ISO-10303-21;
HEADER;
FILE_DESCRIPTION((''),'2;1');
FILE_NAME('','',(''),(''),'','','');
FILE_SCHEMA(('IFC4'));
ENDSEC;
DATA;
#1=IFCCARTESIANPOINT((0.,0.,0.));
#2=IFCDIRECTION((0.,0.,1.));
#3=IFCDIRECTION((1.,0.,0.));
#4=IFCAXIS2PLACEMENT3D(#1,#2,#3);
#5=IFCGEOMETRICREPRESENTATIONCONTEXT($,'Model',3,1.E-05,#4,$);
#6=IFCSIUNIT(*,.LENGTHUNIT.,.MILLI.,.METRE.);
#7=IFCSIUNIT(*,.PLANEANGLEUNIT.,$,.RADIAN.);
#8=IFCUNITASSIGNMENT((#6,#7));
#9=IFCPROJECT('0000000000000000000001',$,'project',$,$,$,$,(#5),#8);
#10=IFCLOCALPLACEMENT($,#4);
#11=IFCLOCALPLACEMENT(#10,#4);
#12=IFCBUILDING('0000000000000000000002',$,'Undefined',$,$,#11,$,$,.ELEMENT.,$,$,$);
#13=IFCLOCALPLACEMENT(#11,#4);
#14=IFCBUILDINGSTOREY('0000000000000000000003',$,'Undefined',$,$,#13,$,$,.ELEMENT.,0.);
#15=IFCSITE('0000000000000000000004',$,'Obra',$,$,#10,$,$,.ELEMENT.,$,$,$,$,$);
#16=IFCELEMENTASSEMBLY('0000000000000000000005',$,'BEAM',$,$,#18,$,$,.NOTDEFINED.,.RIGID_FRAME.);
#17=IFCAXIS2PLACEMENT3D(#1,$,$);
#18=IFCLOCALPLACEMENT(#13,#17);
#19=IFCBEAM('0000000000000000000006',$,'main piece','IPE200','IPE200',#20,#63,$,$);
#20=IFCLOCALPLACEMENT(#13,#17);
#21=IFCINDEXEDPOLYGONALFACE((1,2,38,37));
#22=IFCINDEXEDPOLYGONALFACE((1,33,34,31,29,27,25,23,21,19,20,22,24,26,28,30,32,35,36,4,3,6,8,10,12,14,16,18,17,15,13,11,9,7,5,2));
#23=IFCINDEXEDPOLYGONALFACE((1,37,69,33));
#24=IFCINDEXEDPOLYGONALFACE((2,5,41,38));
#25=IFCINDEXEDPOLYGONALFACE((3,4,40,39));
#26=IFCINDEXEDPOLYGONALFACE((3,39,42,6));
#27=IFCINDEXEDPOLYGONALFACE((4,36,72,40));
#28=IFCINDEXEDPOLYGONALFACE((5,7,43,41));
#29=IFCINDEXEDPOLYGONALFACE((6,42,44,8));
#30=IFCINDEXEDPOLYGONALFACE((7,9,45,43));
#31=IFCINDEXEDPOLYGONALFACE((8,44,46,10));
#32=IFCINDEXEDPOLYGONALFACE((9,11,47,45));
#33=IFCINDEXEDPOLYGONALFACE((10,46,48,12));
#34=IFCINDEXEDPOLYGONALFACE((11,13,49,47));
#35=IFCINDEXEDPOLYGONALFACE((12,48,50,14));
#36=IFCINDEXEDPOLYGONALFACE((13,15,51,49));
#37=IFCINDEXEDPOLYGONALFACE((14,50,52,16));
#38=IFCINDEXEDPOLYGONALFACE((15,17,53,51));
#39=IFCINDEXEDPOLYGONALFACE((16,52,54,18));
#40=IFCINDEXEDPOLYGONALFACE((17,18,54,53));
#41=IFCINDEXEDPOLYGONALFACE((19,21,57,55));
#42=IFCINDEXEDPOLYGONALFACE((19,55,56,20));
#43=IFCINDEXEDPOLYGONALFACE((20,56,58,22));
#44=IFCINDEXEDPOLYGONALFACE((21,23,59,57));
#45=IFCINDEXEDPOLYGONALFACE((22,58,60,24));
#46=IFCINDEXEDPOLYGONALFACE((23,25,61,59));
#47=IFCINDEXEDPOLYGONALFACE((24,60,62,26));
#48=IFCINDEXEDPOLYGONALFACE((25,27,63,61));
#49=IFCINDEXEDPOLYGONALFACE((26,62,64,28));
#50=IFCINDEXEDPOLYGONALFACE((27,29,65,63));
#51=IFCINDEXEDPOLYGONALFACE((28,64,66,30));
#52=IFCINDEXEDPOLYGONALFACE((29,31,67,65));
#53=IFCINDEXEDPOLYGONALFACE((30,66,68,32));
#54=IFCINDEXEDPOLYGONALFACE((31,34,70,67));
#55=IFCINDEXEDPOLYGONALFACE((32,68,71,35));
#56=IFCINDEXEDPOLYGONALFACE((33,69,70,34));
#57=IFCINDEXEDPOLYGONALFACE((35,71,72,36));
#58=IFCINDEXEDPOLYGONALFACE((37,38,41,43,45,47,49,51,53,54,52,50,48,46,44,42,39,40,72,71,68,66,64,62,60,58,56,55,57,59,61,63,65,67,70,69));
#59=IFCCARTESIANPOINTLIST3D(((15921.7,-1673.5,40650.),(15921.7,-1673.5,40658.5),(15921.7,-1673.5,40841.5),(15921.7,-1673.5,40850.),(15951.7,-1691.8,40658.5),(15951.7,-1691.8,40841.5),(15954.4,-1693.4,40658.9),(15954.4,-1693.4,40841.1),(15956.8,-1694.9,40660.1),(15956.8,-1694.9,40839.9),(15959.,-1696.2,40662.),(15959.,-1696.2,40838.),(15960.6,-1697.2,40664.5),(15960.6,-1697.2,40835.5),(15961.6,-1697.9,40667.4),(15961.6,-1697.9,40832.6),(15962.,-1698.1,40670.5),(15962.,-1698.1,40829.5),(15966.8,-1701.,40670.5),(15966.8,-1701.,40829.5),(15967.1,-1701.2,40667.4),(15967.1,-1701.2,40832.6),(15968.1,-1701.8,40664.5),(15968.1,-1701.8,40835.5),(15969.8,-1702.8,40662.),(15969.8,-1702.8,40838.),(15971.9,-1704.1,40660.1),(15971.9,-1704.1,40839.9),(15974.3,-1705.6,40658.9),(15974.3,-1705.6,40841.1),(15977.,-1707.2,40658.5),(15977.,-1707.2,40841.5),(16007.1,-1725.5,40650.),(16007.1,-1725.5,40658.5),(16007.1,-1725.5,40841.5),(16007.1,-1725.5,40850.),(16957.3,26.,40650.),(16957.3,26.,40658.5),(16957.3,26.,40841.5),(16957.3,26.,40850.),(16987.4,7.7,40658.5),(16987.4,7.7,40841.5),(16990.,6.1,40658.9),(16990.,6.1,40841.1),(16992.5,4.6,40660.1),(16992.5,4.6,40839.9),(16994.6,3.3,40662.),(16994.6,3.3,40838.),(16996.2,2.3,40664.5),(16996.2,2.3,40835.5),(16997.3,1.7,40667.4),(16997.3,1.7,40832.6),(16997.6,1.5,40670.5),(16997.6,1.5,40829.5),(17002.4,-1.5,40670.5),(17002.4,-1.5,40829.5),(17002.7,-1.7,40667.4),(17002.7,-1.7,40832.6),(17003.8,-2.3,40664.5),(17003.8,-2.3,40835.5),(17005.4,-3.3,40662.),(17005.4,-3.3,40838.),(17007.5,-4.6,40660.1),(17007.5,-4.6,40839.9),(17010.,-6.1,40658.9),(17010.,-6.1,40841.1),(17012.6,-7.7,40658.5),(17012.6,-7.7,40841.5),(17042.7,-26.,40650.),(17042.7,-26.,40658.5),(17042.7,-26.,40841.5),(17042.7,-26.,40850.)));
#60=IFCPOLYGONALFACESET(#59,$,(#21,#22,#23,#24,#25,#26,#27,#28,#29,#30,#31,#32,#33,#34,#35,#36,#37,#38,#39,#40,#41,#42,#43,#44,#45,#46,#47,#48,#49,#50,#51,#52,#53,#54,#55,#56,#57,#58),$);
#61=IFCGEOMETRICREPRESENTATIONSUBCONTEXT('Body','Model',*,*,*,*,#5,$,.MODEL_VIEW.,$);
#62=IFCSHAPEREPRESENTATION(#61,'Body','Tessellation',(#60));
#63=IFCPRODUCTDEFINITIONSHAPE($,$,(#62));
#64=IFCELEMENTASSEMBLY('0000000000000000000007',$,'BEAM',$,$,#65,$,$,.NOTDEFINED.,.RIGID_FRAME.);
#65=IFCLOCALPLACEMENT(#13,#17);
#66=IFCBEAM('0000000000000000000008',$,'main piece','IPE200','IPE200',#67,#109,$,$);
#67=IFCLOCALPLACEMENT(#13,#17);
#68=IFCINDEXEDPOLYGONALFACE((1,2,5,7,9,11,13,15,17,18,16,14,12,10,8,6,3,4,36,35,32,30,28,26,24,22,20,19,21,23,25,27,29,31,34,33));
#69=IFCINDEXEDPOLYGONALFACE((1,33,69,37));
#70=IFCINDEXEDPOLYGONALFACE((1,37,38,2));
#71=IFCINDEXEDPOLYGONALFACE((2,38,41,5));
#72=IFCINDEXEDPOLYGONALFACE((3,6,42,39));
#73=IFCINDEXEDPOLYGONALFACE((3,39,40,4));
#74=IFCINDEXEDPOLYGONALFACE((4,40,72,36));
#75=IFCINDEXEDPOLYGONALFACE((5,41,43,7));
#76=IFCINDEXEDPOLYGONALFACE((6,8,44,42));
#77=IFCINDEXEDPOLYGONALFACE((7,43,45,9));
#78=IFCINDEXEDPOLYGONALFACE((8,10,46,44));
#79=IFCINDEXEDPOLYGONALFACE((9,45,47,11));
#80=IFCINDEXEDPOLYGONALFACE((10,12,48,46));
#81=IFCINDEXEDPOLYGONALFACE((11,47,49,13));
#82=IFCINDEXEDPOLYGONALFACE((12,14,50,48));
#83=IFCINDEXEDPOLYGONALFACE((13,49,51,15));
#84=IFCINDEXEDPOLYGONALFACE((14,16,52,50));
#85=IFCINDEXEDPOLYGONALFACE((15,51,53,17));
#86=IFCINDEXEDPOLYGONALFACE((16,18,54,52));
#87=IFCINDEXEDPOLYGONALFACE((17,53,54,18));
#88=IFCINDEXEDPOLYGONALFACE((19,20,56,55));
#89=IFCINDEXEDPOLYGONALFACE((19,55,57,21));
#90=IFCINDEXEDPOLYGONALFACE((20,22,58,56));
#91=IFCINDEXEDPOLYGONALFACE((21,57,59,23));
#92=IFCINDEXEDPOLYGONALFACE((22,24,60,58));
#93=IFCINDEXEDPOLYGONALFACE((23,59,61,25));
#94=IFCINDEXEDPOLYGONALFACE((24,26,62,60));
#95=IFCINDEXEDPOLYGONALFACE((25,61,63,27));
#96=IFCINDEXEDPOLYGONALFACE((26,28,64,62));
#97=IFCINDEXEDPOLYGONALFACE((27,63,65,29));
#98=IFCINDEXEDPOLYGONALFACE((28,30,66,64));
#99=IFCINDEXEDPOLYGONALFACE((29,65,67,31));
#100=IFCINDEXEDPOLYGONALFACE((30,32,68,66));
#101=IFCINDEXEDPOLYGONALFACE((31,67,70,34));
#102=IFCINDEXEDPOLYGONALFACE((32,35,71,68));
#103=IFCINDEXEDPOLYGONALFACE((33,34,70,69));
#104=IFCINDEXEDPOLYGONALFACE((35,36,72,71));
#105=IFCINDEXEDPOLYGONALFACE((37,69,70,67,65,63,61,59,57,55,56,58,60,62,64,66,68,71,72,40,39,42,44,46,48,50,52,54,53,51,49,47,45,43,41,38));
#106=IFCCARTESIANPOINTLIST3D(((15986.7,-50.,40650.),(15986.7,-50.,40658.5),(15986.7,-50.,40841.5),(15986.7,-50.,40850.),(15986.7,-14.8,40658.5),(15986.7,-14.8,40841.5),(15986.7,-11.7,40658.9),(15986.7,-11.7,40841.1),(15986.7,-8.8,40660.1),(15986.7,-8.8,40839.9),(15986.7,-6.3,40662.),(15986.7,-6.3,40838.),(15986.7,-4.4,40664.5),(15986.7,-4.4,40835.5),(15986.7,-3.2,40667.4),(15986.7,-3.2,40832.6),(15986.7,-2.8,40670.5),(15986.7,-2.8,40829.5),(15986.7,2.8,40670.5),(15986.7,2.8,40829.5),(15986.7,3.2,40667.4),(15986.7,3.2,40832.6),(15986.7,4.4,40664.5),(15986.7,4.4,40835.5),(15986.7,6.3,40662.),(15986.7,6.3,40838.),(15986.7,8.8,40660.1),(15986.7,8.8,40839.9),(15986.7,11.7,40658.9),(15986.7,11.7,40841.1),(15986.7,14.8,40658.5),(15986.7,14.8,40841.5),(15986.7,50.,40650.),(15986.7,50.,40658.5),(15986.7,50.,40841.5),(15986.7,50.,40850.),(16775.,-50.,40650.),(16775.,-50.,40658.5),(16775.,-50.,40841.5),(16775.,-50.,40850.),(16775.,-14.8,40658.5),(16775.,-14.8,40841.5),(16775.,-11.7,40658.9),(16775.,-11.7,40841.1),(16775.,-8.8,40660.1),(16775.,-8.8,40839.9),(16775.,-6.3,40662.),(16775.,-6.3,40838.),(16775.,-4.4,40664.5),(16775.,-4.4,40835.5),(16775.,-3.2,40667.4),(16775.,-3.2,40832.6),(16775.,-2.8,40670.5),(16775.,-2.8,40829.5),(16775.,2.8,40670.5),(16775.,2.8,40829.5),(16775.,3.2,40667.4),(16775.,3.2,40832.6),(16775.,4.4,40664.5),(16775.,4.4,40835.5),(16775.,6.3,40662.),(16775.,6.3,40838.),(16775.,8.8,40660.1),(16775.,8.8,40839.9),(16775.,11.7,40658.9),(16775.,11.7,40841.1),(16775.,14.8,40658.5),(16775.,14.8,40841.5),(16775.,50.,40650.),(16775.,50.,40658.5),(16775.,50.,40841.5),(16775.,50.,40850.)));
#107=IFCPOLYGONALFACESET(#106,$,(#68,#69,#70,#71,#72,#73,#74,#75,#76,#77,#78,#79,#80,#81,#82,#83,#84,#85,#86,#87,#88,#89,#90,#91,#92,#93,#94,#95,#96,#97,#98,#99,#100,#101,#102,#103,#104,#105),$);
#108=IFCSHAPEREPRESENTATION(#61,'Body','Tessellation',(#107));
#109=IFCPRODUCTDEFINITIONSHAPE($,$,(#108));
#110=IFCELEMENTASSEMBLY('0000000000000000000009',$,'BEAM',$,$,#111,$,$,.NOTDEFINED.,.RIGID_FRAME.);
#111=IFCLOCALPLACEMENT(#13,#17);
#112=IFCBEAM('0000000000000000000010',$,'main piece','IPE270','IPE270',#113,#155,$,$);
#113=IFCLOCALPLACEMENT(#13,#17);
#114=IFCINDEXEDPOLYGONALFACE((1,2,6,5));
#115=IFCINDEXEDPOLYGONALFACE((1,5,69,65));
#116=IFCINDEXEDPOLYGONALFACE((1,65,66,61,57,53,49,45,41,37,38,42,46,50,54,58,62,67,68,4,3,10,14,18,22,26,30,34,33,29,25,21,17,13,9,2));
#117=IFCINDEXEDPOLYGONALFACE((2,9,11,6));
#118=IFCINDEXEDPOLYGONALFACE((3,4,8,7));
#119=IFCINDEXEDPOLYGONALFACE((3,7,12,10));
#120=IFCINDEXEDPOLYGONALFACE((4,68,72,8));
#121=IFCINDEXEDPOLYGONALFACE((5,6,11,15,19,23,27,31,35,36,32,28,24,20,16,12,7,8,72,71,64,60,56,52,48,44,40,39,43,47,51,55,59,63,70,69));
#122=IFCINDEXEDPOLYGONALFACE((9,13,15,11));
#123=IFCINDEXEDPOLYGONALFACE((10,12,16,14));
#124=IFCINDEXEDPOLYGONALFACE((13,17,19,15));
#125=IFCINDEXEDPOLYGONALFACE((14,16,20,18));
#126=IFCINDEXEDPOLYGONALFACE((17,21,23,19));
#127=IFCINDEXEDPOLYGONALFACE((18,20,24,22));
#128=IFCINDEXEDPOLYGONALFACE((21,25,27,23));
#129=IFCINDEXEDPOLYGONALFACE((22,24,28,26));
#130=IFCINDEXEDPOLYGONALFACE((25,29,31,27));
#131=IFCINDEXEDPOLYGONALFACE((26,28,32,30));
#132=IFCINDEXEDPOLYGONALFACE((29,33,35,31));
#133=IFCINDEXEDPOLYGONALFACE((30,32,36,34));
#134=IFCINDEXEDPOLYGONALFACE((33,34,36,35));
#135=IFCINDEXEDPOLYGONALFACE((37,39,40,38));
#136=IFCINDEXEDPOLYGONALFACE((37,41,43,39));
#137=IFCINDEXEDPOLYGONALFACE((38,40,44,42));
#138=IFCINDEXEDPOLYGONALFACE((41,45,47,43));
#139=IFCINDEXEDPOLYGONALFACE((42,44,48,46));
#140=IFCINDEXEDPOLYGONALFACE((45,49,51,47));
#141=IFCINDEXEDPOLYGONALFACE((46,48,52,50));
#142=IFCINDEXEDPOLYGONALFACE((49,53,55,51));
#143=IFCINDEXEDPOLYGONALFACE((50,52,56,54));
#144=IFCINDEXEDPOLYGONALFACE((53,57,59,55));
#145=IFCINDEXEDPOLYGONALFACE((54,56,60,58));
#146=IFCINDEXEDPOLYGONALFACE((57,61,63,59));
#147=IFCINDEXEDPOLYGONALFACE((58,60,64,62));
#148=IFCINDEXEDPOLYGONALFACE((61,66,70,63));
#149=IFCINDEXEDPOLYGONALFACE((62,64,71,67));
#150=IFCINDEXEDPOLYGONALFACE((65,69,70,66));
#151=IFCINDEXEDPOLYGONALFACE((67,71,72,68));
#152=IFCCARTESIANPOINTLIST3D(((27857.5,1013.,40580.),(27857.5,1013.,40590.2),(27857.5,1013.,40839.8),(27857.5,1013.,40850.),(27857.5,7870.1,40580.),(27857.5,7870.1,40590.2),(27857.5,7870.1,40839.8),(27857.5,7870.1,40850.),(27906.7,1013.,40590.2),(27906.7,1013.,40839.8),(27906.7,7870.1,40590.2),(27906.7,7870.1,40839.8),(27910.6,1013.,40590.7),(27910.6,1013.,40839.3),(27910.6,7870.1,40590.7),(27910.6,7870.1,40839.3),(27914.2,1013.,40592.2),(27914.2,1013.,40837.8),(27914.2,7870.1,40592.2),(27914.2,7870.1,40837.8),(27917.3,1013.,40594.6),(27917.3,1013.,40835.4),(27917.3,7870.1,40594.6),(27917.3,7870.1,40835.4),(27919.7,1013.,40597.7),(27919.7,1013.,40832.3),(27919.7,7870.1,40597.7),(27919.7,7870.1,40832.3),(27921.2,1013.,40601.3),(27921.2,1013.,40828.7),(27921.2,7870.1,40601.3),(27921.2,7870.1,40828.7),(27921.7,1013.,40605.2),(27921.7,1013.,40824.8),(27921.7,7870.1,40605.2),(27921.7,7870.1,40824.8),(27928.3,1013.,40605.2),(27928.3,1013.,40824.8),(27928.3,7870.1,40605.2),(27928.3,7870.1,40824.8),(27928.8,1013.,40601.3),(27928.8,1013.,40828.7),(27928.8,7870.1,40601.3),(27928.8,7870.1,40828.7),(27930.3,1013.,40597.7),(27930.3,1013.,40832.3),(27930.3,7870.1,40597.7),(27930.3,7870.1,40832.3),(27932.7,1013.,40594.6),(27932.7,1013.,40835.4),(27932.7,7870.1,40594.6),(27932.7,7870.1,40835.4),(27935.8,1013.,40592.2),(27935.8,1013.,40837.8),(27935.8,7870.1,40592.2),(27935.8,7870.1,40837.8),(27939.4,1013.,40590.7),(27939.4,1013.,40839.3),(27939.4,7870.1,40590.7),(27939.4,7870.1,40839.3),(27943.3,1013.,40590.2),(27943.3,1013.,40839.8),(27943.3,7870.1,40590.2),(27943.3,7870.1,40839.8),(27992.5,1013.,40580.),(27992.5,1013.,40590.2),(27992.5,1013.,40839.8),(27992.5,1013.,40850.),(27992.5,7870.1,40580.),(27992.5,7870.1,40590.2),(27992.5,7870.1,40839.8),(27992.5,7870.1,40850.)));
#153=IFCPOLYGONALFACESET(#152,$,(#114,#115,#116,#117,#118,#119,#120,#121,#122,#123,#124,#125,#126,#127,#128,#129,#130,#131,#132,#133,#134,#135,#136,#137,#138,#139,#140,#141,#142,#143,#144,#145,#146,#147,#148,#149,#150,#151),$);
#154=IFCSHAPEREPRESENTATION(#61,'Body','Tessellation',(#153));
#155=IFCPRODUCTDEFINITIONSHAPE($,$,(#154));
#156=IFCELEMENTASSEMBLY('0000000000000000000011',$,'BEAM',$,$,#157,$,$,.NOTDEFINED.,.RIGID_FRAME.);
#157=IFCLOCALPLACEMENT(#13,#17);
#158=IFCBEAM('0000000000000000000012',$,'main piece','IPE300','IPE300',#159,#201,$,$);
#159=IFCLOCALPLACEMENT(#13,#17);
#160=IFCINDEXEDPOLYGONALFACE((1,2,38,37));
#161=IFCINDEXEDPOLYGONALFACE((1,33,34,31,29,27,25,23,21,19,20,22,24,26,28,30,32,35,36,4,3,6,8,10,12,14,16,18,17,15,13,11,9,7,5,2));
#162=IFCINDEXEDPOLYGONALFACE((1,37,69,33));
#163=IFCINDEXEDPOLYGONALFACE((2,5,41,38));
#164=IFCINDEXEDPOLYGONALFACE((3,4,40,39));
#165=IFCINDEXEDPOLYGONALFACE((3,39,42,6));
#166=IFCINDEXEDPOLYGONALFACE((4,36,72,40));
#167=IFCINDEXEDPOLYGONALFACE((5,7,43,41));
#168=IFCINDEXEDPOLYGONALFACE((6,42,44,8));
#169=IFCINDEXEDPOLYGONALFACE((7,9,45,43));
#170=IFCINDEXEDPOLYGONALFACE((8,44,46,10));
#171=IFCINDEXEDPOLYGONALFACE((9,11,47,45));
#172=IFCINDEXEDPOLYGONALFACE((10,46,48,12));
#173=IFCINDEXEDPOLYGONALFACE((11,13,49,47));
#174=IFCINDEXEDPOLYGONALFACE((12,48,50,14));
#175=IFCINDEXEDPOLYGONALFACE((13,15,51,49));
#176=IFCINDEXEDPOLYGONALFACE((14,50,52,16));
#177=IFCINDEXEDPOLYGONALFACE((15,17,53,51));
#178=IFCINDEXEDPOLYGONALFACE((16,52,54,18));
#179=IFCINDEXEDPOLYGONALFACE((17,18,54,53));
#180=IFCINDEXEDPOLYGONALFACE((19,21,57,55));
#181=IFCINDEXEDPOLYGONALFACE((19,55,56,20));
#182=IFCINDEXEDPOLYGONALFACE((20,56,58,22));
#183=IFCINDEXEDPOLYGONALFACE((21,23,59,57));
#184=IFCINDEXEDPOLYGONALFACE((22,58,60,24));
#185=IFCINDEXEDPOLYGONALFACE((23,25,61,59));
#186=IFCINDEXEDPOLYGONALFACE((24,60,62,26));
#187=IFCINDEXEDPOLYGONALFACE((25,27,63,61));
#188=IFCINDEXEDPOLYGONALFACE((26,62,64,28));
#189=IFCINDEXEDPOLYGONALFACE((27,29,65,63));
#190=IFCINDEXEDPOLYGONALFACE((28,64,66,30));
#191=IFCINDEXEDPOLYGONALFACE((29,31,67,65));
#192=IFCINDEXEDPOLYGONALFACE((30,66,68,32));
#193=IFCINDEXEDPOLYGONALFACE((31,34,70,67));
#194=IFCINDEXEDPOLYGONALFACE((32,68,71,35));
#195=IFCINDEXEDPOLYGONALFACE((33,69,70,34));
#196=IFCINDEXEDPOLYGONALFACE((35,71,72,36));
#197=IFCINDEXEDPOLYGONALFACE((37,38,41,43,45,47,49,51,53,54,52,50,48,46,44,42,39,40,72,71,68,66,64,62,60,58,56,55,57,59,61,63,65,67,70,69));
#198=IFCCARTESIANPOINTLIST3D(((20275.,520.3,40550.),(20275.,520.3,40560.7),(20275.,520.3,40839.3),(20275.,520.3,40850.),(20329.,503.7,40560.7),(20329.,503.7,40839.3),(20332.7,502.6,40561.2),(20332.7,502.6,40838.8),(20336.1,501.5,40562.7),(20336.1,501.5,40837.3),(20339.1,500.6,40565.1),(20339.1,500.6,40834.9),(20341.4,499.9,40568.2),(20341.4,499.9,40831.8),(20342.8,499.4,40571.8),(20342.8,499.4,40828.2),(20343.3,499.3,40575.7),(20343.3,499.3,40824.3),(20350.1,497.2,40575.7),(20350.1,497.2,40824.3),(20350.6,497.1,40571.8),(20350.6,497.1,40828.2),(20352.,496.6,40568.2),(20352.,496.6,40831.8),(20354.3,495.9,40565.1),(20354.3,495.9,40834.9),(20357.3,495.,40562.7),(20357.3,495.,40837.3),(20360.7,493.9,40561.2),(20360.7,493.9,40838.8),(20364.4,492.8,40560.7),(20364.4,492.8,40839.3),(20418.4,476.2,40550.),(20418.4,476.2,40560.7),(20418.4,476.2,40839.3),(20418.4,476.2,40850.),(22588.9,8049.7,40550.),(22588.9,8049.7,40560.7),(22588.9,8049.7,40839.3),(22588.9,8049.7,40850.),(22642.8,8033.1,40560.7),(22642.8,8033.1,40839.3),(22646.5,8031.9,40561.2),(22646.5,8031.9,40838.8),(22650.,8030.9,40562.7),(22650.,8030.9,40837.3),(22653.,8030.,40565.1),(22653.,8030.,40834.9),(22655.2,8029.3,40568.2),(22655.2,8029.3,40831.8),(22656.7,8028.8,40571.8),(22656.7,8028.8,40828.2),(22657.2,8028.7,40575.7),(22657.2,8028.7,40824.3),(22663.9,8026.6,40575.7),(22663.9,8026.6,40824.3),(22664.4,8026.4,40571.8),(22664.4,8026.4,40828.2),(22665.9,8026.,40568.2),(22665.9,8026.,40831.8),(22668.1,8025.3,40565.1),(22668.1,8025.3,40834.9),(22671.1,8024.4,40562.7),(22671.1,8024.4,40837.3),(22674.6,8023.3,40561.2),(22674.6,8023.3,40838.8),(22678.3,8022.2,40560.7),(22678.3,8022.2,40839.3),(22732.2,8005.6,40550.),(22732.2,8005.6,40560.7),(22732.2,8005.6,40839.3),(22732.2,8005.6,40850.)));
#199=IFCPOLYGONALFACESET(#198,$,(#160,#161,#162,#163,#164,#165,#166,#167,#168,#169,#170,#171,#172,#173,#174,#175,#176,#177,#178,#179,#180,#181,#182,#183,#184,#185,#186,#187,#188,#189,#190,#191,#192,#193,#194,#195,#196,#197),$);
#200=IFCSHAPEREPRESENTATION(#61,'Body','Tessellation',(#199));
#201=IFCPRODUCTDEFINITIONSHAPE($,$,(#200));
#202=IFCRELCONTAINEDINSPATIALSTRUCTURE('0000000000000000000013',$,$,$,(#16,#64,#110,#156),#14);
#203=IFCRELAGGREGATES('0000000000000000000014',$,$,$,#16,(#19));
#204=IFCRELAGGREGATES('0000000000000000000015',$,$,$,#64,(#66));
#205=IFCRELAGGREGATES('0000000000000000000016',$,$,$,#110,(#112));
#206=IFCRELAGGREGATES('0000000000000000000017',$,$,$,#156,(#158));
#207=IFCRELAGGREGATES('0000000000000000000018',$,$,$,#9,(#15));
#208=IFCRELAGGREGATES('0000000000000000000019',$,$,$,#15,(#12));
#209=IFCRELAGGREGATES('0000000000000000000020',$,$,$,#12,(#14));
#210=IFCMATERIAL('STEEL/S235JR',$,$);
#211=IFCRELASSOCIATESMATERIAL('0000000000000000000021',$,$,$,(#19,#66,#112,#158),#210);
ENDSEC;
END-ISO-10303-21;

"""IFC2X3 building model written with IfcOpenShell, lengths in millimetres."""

from ifc_helpers import new_model, si_unit, frame, origin_with_axes, origin_2d_with_axis, place, context, subcontext, project, spatial, i_section, extrude, material, element, aggregate, save


model = new_model("IFC2X3")

# Units and contexts
model_context = context("Model", 3, precision=1e-05, world=origin_with_axes())
body_context = subcontext(model_context, "Body", "Model", "MODEL_VIEW")
ifc_project = project(units=[si_unit("LENGTHUNIT", "METRE", prefix="MILLI"), si_unit("PLANEANGLEUNIT", "RADIAN")], contexts=[model_context])

# Site, building, storey
site_placement = place(None, origin_with_axes())
site = spatial("IfcSite", under=ifc_project, at=site_placement, Name="Obra", CompositionType="ELEMENT")
building_placement = place(site_placement, origin_with_axes())
building = spatial("IfcBuilding", under=site, at=building_placement, Name="Undefined", CompositionType="ELEMENT")
storey_placement = place(building_placement, origin_with_axes())
storey = spatial("IfcBuildingStorey", under=building, at=storey_placement, Name="Undefined", CompositionType="ELEMENT", Elevation=0.0)

# Shared definitions
ifc_material_1 = material(Name="STEEL/S235JR")

# Element assemblies, beams
assembly_1_placement = place(storey_placement, origin_with_axes())
assembly_1 = element("IfcElementAssembly", 1, at=assembly_1_placement, inside=storey, Name="BEAM", AssemblyPlace="NOTDEFINED", PredefinedType="RIGID_FRAME")
beam_1_placement = place(assembly_1_placement, frame((17000.0, 0.0, 40750.0), z_axis=(0.0, 0.0, 1.0), x_axis=(-0.520368, -0.853942, 0.0)))
beam_1 = element("IfcBeam", 2, at=beam_1_placement, material=ifc_material_1, Name="main piece", Description="IPE200", ObjectType="IPE200", context=body_context, shape_type="SweptSolid", body=[
    extrude(i_section(OverallWidth=100.0, OverallDepth=200.0, WebThickness=5.6, FlangeThickness=8.5, FilletRadius=12.0, at=origin_2d_with_axis()), frame((1990.2, 0.0, 0.0), z_axis=(-1.0, 0.0, 0.0), x_axis=(0.0, -1.0, 0.0)), (0.0, 0.0, 1.0), 1990.2),
])
aggregate(assembly_1, [beam_1])
assembly_2_placement = place(storey_placement, origin_with_axes())
assembly_2 = element("IfcElementAssembly", 3, at=assembly_2_placement, inside=storey, Name="BEAM", AssemblyPlace="NOTDEFINED", PredefinedType="RIGID_FRAME")
beam_2_placement = place(assembly_2_placement, frame((16775.0, 0.0, 40750.0), z_axis=(0.0, 0.0, 1.0), x_axis=(-1.0, 0.0, 0.0)))
beam_2 = element("IfcBeam", 4, at=beam_2_placement, material=ifc_material_1, Name="main piece", Description="IPE200", ObjectType="IPE200", context=body_context, shape_type="SweptSolid", body=[
    extrude(i_section(OverallWidth=100.0, OverallDepth=200.0, WebThickness=5.6, FlangeThickness=8.5, FilletRadius=12.0, at=origin_2d_with_axis()), frame((788.3, 0.0, 0.0), z_axis=(-1.0, 0.0, 0.0), x_axis=(0.0, -1.0, 0.0)), (0.0, 0.0, 1.0), 788.3),
])
aggregate(assembly_2, [beam_2])
assembly_3_placement = place(storey_placement, origin_with_axes())
assembly_3 = element("IfcElementAssembly", 5, at=assembly_3_placement, inside=storey, Name="BEAM", AssemblyPlace="NOTDEFINED", PredefinedType="RIGID_FRAME")
beam_3_placement = place(assembly_3_placement, frame((27925.0, 1013.0, 40715.0), z_axis=(0.0, 0.0, 1.0), x_axis=(0.0, 1.0, 0.0)))
beam_3 = element("IfcBeam", 6, at=beam_3_placement, material=ifc_material_1, Name="main piece", Description="IPE270", ObjectType="IPE270", context=body_context, shape_type="SweptSolid", body=[
    extrude(i_section(OverallWidth=135.0, OverallDepth=270.0, WebThickness=6.6, FlangeThickness=10.2, FilletRadius=15.0, at=origin_2d_with_axis()), frame((6857.1, 0.0, 0.0), z_axis=(-1.0, 0.0, 0.0), x_axis=(0.0, -1.0, 0.0)), (0.0, 0.0, 1.0), 6857.1),
])
aggregate(assembly_3, [beam_3])
assembly_4_placement = place(storey_placement, origin_with_axes())
assembly_4 = element("IfcElementAssembly", 7, at=assembly_4_placement, inside=storey, Name="BEAM", AssemblyPlace="NOTDEFINED", PredefinedType="RIGID_FRAME")
beam_4_placement = place(assembly_4_placement, frame((20346.7, 498.2, 40700.0), z_axis=(0.0, 0.0, 1.0), x_axis=(0.293752, 0.955882, 0.0)))
beam_4 = element("IfcBeam", 8, at=beam_4_placement, material=ifc_material_1, Name="main piece", Description="IPE300", ObjectType="IPE300", context=body_context, shape_type="SweptSolid", body=[
    extrude(i_section(OverallWidth=150.0, OverallDepth=300.0, WebThickness=7.1, FlangeThickness=10.7, FilletRadius=15.0, at=origin_2d_with_axis()), frame((7876.9, 0.0, 0.0), z_axis=(-1.0, 0.0, 0.0), x_axis=(0.0, -1.0, 0.0)), (0.0, 0.0, 1.0), 7876.9),
])
aggregate(assembly_4, [beam_4])

save(model, "model.ifc")
